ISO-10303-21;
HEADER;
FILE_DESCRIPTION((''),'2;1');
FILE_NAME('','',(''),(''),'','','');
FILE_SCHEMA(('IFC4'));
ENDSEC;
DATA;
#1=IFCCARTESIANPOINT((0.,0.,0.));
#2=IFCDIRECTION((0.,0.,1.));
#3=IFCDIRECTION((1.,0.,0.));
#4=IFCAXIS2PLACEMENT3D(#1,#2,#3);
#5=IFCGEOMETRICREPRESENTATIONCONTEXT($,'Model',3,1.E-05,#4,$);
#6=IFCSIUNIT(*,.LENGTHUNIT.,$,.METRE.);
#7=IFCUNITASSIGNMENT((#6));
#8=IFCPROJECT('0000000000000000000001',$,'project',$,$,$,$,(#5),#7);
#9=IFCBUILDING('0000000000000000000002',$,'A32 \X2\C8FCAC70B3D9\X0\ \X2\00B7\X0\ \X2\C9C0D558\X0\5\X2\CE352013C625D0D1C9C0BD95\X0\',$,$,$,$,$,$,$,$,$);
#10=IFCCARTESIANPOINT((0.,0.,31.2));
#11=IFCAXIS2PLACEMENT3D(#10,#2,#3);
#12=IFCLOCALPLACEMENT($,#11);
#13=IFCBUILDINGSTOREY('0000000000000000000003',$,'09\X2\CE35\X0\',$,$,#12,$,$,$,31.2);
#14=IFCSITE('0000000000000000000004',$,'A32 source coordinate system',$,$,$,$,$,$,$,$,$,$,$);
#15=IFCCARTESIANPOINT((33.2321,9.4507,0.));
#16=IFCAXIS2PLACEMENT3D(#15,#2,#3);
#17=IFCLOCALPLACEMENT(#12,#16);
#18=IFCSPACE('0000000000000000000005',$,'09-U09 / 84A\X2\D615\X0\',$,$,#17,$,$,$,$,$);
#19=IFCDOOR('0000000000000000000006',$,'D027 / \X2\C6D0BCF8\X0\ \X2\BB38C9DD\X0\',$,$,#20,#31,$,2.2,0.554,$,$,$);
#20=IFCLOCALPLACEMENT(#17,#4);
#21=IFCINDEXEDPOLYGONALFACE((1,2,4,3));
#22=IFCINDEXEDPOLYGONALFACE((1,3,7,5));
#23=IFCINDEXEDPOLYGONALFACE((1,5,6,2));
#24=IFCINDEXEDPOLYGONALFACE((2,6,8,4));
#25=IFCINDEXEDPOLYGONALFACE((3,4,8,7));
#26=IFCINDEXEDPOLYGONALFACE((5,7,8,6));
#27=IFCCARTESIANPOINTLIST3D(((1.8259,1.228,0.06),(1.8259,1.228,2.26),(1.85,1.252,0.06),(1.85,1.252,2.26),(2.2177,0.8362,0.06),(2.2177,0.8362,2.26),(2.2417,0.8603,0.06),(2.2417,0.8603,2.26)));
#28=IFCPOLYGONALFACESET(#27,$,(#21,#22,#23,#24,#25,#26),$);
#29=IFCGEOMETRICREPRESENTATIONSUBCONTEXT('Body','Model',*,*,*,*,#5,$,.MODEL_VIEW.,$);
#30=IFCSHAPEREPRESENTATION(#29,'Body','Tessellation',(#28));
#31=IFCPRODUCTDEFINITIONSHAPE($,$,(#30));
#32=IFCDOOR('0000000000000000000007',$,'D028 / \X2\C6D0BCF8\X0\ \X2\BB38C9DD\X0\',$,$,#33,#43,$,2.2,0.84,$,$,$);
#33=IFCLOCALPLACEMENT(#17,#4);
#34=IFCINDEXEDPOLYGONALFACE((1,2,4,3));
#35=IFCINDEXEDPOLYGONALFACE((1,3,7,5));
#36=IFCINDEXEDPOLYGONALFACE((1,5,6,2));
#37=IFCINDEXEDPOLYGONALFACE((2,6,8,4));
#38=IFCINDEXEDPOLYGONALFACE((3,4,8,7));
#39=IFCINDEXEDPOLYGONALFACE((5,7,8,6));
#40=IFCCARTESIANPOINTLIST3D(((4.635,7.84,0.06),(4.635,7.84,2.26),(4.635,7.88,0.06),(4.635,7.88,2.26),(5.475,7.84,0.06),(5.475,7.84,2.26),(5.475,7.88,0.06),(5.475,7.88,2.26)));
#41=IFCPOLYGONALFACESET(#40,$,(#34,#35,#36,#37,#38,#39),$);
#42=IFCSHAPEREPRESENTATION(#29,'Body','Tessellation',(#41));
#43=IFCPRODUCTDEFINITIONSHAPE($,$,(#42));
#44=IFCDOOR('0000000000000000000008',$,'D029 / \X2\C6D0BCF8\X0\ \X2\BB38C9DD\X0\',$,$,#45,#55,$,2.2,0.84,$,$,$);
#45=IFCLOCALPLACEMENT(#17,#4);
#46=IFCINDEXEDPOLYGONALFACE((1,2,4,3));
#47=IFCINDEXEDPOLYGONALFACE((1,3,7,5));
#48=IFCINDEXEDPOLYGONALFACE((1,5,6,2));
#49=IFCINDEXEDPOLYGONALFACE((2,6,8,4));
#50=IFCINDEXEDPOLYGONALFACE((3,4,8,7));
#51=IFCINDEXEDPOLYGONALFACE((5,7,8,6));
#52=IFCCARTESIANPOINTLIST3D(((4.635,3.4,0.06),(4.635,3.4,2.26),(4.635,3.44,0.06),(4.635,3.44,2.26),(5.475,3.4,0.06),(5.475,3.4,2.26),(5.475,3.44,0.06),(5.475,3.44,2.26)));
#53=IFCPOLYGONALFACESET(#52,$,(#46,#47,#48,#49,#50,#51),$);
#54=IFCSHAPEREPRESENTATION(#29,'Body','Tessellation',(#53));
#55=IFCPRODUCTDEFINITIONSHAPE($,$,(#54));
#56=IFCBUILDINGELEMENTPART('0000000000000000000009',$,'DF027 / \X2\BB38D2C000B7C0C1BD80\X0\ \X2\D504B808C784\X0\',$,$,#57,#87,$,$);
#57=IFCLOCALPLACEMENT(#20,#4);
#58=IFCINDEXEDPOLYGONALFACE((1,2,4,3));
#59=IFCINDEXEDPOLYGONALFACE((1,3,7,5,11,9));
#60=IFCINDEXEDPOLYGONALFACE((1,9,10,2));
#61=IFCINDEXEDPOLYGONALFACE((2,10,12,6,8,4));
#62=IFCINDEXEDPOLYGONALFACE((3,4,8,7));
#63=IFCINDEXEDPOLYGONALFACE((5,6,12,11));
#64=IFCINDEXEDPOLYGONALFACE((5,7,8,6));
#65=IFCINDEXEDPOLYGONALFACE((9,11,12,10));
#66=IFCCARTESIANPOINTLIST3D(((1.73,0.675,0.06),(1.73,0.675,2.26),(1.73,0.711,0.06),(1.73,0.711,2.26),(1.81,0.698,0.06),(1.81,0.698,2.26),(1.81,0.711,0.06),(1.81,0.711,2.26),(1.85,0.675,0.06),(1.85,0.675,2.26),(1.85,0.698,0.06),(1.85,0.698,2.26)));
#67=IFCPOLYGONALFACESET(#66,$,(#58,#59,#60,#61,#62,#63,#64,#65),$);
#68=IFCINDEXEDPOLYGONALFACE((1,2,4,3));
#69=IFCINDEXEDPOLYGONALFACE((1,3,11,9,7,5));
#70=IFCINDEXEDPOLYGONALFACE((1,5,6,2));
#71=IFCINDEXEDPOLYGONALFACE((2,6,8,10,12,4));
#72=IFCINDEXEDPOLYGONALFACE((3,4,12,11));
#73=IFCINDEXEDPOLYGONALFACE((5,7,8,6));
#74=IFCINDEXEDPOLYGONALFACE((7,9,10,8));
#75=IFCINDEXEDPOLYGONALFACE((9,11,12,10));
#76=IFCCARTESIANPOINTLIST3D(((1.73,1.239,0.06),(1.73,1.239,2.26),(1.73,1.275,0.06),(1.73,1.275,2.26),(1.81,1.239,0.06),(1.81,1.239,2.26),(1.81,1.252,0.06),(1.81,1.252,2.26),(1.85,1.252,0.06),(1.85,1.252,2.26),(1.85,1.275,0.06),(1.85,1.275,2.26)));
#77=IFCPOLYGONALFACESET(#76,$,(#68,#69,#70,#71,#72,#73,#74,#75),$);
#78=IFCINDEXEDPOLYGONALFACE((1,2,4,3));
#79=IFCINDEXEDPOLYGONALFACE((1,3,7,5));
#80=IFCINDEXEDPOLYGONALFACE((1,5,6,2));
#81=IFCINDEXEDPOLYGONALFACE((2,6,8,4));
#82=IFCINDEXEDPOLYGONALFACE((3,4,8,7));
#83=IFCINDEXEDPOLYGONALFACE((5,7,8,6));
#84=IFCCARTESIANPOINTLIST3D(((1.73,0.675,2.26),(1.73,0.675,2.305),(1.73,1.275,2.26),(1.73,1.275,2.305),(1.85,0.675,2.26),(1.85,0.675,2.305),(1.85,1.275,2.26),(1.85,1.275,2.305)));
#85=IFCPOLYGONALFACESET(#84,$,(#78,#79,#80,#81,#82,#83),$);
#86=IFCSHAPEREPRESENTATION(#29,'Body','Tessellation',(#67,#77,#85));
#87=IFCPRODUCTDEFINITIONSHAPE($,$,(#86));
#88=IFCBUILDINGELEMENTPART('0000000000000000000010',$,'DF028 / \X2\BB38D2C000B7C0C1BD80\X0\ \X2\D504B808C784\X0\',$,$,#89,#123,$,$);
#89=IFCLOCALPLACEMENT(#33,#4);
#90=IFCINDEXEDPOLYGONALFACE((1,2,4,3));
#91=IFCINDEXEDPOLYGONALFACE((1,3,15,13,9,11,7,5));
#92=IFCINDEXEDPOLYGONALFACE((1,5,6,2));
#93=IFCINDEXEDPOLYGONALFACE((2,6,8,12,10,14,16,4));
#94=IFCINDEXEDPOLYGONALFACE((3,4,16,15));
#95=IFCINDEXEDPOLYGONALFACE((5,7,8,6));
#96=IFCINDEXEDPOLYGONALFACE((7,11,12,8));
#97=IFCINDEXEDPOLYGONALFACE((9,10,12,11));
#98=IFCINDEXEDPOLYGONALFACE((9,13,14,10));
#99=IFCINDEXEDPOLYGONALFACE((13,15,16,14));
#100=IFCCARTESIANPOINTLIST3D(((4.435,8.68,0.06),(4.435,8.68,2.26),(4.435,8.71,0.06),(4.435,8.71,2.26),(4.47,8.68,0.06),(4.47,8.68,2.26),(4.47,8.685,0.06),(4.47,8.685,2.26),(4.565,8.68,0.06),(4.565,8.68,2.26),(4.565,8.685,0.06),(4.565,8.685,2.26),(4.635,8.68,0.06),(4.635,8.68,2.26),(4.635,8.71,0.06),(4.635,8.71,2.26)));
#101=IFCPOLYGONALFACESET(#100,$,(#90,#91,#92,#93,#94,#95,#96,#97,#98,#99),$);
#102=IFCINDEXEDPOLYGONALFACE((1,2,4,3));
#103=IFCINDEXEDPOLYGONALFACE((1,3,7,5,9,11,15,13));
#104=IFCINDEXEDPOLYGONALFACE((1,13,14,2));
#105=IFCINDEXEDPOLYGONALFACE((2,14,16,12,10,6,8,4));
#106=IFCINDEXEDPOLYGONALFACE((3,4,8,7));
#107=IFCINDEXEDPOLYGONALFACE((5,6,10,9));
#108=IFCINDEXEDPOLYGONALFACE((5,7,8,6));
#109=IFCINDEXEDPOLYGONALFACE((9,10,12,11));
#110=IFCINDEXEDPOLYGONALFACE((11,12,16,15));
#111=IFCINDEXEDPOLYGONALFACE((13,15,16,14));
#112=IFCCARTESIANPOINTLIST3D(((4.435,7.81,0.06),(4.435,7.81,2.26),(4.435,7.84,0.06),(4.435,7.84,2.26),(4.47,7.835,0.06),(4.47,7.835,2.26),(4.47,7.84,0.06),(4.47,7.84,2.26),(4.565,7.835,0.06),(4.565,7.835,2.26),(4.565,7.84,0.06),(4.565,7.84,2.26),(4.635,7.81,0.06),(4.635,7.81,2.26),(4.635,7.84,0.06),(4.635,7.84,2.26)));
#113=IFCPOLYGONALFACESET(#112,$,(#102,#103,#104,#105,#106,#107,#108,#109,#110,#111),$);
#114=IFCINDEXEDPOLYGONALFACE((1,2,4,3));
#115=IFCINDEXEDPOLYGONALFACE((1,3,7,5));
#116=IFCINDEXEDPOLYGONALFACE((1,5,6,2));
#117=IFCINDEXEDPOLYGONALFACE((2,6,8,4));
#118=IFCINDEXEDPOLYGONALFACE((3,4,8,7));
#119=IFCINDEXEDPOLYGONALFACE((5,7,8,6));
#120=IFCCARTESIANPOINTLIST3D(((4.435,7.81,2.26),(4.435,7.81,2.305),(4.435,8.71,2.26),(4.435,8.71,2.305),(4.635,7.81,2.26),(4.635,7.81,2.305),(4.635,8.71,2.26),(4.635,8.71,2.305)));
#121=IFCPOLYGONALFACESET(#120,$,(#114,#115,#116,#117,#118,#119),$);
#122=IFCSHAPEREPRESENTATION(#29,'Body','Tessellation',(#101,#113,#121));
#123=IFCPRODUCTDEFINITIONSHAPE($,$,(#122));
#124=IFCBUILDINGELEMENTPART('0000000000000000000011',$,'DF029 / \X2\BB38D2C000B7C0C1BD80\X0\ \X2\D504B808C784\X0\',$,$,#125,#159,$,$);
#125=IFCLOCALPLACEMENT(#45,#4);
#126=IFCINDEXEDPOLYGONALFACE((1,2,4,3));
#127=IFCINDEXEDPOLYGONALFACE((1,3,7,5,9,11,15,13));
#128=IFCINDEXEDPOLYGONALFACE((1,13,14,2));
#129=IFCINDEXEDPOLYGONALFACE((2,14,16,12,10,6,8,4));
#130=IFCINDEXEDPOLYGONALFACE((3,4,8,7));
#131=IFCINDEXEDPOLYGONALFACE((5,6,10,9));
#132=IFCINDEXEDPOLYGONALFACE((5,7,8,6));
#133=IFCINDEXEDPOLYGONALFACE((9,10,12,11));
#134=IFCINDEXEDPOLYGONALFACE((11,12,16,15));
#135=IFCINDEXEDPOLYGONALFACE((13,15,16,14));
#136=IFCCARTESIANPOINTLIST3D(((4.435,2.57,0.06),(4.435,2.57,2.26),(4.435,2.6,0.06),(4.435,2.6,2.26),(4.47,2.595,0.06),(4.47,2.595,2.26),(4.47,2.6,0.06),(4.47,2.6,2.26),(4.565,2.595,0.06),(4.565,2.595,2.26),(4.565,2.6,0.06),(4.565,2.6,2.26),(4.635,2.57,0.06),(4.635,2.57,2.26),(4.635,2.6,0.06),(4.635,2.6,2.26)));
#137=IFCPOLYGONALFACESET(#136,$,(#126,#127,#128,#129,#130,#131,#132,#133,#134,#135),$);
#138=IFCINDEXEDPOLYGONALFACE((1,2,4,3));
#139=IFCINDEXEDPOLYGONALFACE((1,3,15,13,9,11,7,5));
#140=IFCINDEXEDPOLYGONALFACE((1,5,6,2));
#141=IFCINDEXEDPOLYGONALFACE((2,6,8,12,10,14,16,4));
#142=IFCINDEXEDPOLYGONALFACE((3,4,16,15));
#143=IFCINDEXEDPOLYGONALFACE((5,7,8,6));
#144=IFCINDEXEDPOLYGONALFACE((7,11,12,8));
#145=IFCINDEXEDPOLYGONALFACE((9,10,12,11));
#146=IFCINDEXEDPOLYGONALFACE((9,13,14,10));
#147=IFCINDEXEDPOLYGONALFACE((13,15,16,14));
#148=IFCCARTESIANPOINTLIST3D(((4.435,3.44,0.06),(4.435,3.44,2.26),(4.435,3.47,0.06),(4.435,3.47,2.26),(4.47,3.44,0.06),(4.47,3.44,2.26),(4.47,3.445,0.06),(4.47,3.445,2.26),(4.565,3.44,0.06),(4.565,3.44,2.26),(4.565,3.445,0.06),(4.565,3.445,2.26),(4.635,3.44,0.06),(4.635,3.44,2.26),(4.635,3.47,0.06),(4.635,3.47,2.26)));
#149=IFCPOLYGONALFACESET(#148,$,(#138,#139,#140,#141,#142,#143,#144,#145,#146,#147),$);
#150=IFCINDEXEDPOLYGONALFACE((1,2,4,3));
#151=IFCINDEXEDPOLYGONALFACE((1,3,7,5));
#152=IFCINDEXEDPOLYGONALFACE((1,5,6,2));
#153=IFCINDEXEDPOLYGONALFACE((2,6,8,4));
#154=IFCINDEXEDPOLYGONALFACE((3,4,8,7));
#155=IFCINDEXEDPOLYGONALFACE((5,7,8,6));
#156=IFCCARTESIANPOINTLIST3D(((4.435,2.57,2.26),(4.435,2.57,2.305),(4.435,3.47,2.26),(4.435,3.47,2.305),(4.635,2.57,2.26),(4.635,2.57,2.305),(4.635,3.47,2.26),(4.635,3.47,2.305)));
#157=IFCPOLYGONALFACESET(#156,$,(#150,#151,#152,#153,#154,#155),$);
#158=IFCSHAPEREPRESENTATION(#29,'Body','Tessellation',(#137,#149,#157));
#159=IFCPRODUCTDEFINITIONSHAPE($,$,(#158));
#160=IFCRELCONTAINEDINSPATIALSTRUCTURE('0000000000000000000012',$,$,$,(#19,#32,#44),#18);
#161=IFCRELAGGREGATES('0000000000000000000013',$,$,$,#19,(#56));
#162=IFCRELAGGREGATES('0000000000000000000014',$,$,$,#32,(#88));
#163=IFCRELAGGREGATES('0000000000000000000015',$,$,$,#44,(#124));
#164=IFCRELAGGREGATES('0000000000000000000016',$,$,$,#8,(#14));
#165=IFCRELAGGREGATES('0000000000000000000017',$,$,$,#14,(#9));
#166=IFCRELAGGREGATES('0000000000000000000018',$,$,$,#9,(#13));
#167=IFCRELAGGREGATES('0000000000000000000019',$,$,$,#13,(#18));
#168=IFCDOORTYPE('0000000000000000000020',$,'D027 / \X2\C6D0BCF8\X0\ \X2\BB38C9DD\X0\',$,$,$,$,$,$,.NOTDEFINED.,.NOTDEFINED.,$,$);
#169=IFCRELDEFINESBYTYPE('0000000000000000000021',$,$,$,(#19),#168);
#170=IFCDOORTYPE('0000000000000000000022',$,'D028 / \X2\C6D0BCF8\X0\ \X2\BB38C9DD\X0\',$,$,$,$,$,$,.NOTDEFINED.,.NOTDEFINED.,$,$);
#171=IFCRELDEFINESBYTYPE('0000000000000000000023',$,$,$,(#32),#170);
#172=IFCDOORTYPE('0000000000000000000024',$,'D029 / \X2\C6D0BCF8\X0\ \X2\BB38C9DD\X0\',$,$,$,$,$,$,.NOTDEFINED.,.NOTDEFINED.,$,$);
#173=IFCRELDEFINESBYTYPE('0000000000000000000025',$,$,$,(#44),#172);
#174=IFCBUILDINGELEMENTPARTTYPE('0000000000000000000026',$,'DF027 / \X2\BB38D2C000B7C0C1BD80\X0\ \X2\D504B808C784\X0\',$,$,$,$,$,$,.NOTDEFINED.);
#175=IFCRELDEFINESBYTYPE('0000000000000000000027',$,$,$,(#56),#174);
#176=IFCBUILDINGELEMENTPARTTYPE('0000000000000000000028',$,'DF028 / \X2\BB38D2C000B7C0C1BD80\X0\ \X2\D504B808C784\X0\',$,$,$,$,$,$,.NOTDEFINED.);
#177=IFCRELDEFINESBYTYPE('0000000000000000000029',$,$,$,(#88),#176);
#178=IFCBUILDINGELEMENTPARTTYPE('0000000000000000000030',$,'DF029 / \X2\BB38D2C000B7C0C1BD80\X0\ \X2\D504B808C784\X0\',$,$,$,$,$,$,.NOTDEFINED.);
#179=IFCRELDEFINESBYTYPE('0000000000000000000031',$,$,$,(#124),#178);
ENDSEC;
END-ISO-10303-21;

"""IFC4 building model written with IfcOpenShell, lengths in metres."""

from ifc_helpers import new_model, si_unit, frame, origin, origin_with_axes, place, context, subcontext, project, spatial, polyline, outline, extrude, source, transform, mapped, type_object, type_shapes, element, aggregate, save


model = new_model("IFC4")

# Units and contexts
model_context = context("Model", 3, precision=1e-05, world=origin_with_axes())
body_context = subcontext(model_context, "Body", "Model", "MODEL_VIEW")
ifc_project = project(units=[si_unit("LENGTHUNIT", "METRE")], contexts=[model_context])

# Site, building, storey, space
storey_placement = place(None, frame((0.0, 0.0, 31.2), z_axis=(0.0, 0.0, 1.0), x_axis=(1.0, 0.0, 0.0)))
space_placement = place(storey_placement, frame((33.2321, 9.4507, 0.0), z_axis=(0.0, 0.0, 1.0), x_axis=(1.0, 0.0, 0.0)))
site = spatial("IfcSite", under=ifc_project, Name="A32 source coordinate system")
building = spatial("IfcBuilding", under=site, Name="A32 주거동 · 지하5층–옥탑지붕")
storey = spatial("IfcBuildingStorey", under=building, at=storey_placement, Name="09층", Elevation=31.2)
space = spatial("IfcSpace", under=storey, at=space_placement, Name="09-U09 / 84A형")

# Doors
door_type_1 = type_object("IfcDoorType", Name="D027 / 원본 문짝", OperationType="NOTDEFINED", PredefinedType="NOTDEFINED")
shared_shape_1 = source(origin(), body_context, "Body", "SweptSolid", [
    extrude(outline(polyline([(1.85, 1.252), (2.2417, 0.8603), (2.2177, 0.8362), (1.8259, 1.228), (1.85, 1.252)])), frame((0.0, 0.0, 0.06)), (0.0, 0.0, 1.0), 2.2),
])
type_shapes(door_type_1, [shared_shape_1])
door_1_placement = place(space_placement, origin_with_axes())
door_1 = element("IfcDoor", 1, at=door_1_placement, inside=space, type_object=door_type_1, Name="D027 / 원본 문짝", OverallHeight=2.2, OverallWidth=0.554, context=body_context, shape_type="MappedRepresentation", body=[
    mapped(shared_shape_1, transform((0.0, 0.0, 0.0), scale=1.0)),
])
door_type_2 = type_object("IfcDoorType", Name="D028 / 원본 문짝", OperationType="NOTDEFINED", PredefinedType="NOTDEFINED")
shared_shape_2 = source(origin(), body_context, "Body", "SweptSolid", [
    extrude(outline(polyline([(5.475, 7.88), (5.475, 7.84), (4.635, 7.84), (4.635, 7.88), (5.475, 7.88)])), frame((0.0, 0.0, 0.06)), (0.0, 0.0, 1.0), 2.2),
])
type_shapes(door_type_2, [shared_shape_2])
door_2_placement = place(space_placement, origin_with_axes())
door_2 = element("IfcDoor", 2, at=door_2_placement, inside=space, type_object=door_type_2, Name="D028 / 원본 문짝", OverallHeight=2.2, OverallWidth=0.84, context=body_context, shape_type="MappedRepresentation", body=[
    mapped(shared_shape_2, transform((0.0, 0.0, 0.0), scale=1.0)),
])
door_type_3 = type_object("IfcDoorType", Name="D029 / 원본 문짝", OperationType="NOTDEFINED", PredefinedType="NOTDEFINED")
shared_shape_3 = source(origin(), body_context, "Body", "SweptSolid", [
    extrude(outline(polyline([(4.635, 3.44), (5.475, 3.44), (5.475, 3.4), (4.635, 3.4), (4.635, 3.44)])), frame((0.0, 0.0, 0.06)), (0.0, 0.0, 1.0), 2.2),
])
type_shapes(door_type_3, [shared_shape_3])
door_3_placement = place(space_placement, origin_with_axes())
door_3 = element("IfcDoor", 3, at=door_3_placement, inside=space, type_object=door_type_3, Name="D029 / 원본 문짝", OverallHeight=2.2, OverallWidth=0.84, context=body_context, shape_type="MappedRepresentation", body=[
    mapped(shared_shape_3, transform((0.0, 0.0, 0.0), scale=1.0)),
])

# Building element parts
building_element_part_type_1 = type_object("IfcBuildingElementPartType", Name="DF027 / 문틀·상부 프레임", PredefinedType="NOTDEFINED")
shared_shape_4 = source(origin(), body_context, "Body", "SweptSolid", [
    extrude(outline(polyline([(1.73, 0.711), (1.81, 0.711), (1.81, 0.698), (1.85, 0.698), (1.85, 0.675), (1.73, 0.675), (1.73, 0.711)])), frame((0.0, 0.0, 0.06)), (0.0, 0.0, 1.0), 2.2),
    extrude(outline(polyline([(1.85, 1.275), (1.85, 1.252), (1.81, 1.252), (1.81, 1.239), (1.73, 1.239), (1.73, 1.275), (1.85, 1.275)])), frame((0.0, 0.0, 0.06)), (0.0, 0.0, 1.0), 2.2),
    extrude(outline(polyline([(1.73, 0.675), (1.73, 1.275), (1.85, 1.275), (1.85, 0.675), (1.73, 0.675)])), frame((0.0, 0.0, 2.26)), (0.0, 0.0, 1.0), 0.045),
])
type_shapes(building_element_part_type_1, [shared_shape_4])
building_element_part_1_placement = place(door_1_placement, origin_with_axes())
building_element_part_1 = element("IfcBuildingElementPart", 4, at=building_element_part_1_placement, type_object=building_element_part_type_1, Name="DF027 / 문틀·상부 프레임", context=body_context, shape_type="MappedRepresentation", body=[
    mapped(shared_shape_4, transform((0.0, 0.0, 0.0), scale=1.0)),
])
aggregate(door_1, [building_element_part_1])
building_element_part_type_2 = type_object("IfcBuildingElementPartType", Name="DF028 / 문틀·상부 프레임", PredefinedType="NOTDEFINED")
shared_shape_5 = source(origin(), body_context, "Body", "SweptSolid", [
    extrude(outline(polyline([(4.635, 8.68), (4.565, 8.68), (4.565, 8.685), (4.47, 8.685), (4.47, 8.68), (4.435, 8.68), (4.435, 8.71), (4.635, 8.71), (4.635, 8.68)])), frame((0.0, 0.0, 0.06)), (0.0, 0.0, 1.0), 2.2),
    extrude(outline(polyline([(4.435, 7.81), (4.435, 7.84), (4.47, 7.84), (4.47, 7.835), (4.565, 7.835), (4.565, 7.84), (4.635, 7.84), (4.635, 7.81), (4.435, 7.81)])), frame((0.0, 0.0, 0.06)), (0.0, 0.0, 1.0), 2.2),
    extrude(outline(polyline([(4.435, 7.81), (4.435, 8.71), (4.635, 8.71), (4.635, 7.81), (4.435, 7.81)])), frame((0.0, 0.0, 2.26)), (0.0, 0.0, 1.0), 0.045),
])
type_shapes(building_element_part_type_2, [shared_shape_5])
building_element_part_2_placement = place(door_2_placement, origin_with_axes())
building_element_part_2 = element("IfcBuildingElementPart", 5, at=building_element_part_2_placement, type_object=building_element_part_type_2, Name="DF028 / 문틀·상부 프레임", context=body_context, shape_type="MappedRepresentation", body=[
    mapped(shared_shape_5, transform((0.0, 0.0, 0.0), scale=1.0)),
])
aggregate(door_2, [building_element_part_2])
building_element_part_type_3 = type_object("IfcBuildingElementPartType", Name="DF029 / 문틀·상부 프레임", PredefinedType="NOTDEFINED")
shared_shape_6 = source(origin(), body_context, "Body", "SweptSolid", [
    extrude(outline(polyline([(4.435, 2.57), (4.435, 2.6), (4.47, 2.6), (4.47, 2.595), (4.565, 2.595), (4.565, 2.6), (4.635, 2.6), (4.635, 2.57), (4.435, 2.57)])), frame((0.0, 0.0, 0.06)), (0.0, 0.0, 1.0), 2.2),
    extrude(outline(polyline([(4.635, 3.44), (4.565, 3.44), (4.565, 3.445), (4.47, 3.445), (4.47, 3.44), (4.435, 3.44), (4.435, 3.47), (4.635, 3.47), (4.635, 3.44)])), frame((0.0, 0.0, 0.06)), (0.0, 0.0, 1.0), 2.2),
    extrude(outline(polyline([(4.435, 2.57), (4.435, 3.47), (4.635, 3.47), (4.635, 2.57), (4.435, 2.57)])), frame((0.0, 0.0, 2.26)), (0.0, 0.0, 1.0), 0.045),
])
type_shapes(building_element_part_type_3, [shared_shape_6])
building_element_part_3_placement = place(door_3_placement, origin_with_axes())
building_element_part_3 = element("IfcBuildingElementPart", 6, at=building_element_part_3_placement, type_object=building_element_part_type_3, Name="DF029 / 문틀·상부 프레임", context=body_context, shape_type="MappedRepresentation", body=[
    mapped(shared_shape_6, transform((0.0, 0.0, 0.0), scale=1.0)),
])
aggregate(door_3, [building_element_part_3])

save(model, "model.ifc")
